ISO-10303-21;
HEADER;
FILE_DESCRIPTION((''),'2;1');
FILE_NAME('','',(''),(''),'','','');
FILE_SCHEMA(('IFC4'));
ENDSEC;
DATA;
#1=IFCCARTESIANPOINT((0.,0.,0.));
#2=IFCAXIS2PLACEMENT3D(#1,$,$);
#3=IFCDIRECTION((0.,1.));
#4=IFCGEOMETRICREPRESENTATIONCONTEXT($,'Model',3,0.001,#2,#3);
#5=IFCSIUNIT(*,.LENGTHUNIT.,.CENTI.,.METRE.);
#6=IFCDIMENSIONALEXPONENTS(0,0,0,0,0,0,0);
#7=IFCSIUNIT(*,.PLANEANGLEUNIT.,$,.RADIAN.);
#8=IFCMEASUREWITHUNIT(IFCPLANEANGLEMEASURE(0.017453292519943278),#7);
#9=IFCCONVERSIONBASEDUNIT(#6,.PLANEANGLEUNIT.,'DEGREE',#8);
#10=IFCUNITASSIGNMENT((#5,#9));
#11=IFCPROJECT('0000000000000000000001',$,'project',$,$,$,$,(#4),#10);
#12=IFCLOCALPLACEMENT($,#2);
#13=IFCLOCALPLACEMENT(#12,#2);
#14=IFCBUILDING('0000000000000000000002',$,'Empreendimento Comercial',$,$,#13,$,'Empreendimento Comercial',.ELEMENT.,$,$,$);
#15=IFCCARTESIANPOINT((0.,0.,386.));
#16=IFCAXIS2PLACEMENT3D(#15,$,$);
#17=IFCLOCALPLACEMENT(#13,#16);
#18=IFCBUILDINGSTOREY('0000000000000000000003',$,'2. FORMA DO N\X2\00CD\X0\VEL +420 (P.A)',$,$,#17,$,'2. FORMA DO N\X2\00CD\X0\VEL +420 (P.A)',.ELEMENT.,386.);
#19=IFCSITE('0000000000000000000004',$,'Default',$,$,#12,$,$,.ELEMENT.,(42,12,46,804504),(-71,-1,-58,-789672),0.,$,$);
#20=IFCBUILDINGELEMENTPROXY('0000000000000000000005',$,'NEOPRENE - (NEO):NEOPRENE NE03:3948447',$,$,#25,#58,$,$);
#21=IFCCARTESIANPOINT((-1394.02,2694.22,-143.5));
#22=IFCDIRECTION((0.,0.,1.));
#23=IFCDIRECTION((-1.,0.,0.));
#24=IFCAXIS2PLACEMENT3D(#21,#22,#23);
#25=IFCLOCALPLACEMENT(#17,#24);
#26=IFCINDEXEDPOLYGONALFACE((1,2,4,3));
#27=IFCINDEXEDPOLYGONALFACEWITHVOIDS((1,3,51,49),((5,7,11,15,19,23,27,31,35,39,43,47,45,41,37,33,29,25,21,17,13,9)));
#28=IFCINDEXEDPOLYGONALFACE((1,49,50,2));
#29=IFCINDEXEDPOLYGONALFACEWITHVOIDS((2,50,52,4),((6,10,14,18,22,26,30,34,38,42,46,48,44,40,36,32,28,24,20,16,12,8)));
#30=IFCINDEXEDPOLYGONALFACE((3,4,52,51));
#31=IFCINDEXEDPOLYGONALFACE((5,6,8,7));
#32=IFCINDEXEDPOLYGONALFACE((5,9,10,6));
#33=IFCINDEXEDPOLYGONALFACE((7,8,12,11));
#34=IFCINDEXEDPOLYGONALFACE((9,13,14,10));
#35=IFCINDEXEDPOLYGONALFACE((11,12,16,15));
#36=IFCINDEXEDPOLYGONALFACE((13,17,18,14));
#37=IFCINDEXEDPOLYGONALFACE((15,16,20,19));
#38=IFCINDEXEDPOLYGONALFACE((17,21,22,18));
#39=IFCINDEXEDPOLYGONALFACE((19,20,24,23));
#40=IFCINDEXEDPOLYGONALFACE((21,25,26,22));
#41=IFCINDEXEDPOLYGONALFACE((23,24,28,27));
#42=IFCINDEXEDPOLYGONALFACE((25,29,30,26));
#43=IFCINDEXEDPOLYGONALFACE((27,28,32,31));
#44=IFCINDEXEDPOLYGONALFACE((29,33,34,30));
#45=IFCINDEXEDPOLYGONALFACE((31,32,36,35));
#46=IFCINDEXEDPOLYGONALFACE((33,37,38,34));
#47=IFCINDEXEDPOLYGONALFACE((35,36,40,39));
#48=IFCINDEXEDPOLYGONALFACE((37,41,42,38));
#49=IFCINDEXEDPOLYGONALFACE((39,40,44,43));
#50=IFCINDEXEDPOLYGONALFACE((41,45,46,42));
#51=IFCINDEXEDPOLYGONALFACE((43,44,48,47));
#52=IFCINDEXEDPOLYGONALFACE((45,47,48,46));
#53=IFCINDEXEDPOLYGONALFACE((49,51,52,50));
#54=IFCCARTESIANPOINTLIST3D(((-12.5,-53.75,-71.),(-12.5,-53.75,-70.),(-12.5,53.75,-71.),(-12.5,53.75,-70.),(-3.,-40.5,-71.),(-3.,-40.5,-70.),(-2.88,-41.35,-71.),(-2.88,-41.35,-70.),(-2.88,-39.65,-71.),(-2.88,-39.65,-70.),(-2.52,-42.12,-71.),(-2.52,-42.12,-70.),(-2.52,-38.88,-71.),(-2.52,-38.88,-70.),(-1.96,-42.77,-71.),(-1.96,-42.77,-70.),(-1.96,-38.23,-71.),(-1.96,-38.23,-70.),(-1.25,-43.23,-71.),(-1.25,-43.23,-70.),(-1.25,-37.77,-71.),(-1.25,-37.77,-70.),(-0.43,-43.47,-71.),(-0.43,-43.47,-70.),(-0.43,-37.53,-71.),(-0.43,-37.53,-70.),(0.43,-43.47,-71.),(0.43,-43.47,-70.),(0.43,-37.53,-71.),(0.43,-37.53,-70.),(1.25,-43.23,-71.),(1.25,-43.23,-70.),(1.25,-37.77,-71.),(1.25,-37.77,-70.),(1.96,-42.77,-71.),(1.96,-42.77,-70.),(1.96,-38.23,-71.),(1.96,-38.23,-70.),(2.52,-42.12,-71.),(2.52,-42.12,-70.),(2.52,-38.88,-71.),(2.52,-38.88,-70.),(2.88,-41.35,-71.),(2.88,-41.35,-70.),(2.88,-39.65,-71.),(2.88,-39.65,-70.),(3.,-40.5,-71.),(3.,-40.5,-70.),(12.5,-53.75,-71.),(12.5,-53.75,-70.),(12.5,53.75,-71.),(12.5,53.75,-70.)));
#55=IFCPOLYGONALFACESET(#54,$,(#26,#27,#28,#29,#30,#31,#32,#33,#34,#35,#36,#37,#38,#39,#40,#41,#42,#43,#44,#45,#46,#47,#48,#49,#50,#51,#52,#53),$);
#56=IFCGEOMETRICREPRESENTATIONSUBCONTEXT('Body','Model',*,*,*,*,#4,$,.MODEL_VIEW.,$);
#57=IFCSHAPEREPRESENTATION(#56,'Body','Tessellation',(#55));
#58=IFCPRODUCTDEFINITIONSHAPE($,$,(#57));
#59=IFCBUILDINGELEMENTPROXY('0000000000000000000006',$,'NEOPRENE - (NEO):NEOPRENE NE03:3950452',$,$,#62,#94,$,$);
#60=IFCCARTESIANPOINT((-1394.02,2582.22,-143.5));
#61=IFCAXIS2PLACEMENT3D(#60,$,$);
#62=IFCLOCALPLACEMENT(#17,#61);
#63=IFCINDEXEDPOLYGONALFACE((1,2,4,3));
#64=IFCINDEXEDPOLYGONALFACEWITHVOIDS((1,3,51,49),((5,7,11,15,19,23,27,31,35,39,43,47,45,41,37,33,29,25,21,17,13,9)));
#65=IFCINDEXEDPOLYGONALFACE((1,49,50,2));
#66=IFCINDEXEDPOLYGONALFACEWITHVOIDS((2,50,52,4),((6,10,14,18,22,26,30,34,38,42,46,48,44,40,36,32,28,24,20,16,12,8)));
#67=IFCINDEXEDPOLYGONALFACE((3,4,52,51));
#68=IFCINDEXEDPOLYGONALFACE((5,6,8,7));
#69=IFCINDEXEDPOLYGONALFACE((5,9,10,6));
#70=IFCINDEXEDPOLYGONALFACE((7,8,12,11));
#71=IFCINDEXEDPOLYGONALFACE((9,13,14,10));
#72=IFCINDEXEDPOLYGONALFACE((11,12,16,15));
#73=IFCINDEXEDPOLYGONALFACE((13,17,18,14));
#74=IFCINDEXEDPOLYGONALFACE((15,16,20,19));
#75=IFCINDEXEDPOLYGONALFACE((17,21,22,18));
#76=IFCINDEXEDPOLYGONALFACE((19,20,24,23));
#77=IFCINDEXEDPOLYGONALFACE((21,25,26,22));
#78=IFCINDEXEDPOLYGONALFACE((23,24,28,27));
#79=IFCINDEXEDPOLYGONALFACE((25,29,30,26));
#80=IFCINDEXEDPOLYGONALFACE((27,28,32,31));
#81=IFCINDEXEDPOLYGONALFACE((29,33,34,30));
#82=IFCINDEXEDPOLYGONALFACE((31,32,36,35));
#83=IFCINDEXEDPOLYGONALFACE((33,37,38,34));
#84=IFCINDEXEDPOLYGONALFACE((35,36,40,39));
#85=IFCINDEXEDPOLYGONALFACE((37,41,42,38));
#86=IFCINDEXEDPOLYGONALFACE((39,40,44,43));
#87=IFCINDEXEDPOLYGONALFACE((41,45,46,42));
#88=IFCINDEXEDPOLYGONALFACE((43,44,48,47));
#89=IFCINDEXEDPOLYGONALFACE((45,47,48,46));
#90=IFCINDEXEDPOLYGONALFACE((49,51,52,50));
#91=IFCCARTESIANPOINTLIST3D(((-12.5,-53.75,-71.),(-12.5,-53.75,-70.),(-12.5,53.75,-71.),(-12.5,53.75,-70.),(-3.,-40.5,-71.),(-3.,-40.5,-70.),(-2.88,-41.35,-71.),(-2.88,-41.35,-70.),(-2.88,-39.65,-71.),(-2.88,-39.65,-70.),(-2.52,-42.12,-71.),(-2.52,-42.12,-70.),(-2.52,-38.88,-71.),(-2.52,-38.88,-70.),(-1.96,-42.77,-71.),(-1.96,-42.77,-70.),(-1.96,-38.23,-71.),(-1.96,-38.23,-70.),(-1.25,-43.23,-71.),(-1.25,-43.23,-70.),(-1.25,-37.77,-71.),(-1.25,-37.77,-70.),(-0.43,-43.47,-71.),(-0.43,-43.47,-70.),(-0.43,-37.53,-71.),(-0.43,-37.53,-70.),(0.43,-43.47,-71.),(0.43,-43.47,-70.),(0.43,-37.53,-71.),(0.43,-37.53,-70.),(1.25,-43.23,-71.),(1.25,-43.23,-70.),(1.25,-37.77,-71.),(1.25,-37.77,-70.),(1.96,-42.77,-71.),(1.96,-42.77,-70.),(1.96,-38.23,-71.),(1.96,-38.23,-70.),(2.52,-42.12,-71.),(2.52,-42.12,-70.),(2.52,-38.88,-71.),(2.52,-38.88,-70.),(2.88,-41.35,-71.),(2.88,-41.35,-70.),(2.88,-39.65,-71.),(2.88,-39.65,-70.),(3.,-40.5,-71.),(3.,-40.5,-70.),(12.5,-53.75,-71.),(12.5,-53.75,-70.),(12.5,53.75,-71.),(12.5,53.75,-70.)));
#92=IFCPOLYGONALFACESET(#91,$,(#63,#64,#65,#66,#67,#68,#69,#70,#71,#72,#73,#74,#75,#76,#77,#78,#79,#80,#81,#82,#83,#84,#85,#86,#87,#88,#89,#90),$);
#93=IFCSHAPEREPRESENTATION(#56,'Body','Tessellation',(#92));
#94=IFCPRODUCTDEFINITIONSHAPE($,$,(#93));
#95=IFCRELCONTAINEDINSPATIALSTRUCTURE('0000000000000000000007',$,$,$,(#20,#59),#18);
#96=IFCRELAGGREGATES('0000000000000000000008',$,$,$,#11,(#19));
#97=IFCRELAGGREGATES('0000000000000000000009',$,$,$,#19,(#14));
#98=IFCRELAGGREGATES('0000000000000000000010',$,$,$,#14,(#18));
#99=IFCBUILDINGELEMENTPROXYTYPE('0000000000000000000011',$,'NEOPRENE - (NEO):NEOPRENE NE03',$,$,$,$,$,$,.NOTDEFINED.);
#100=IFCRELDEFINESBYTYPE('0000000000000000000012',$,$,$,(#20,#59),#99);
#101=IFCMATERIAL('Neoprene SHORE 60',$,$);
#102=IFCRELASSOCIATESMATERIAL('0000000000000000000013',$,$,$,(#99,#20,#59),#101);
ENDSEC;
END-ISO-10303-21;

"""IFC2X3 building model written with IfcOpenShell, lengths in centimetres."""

from ifc_helpers import new_model, entity, si_unit, converted_unit, direction, frame, frame_2d, origin, place, context, subcontext, project, spatial, polyline, circle_curve, parameter, trimmed, segment, composite_curve, outline, extrude, source, transform, mapped, material, type_object, type_shapes, element, save


model = new_model("IFC2X3")

# Units and contexts
model_context = context("Model", 3, precision=0.001, world=origin(), true_north=direction((0.0, 1.0)))
body_context = subcontext(model_context, "Body", "Model", "MODEL_VIEW")
ifc_project = project(units=[si_unit("LENGTHUNIT", "METRE", prefix="CENTI"), converted_unit("PLANEANGLEUNIT", "DEGREE", entity("IfcPlaneAngleMeasure", 0.017453292519943278), si_unit("PLANEANGLEUNIT", "RADIAN"), dimensions=[0, 0, 0, 0, 0, 0, 0])], contexts=[model_context])

# Site, building, storey
site_placement = place(None, origin())
site = spatial("IfcSite", under=ifc_project, at=site_placement, Name="Default", CompositionType="ELEMENT", RefLatitude=(42, 12, 46, 804504), RefLongitude=(-71, -1, -58, -789672), RefElevation=0.0)
building_placement = place(site_placement, origin())
building = spatial("IfcBuilding", under=site, at=building_placement, Name="Empreendimento Comercial", LongName="Empreendimento Comercial", CompositionType="ELEMENT")
storey_placement = place(building_placement, frame((0.0, 0.0, 386.0)))
storey = spatial("IfcBuildingStorey", under=building, at=storey_placement, Name="2. FORMA DO NÍVEL +420 (P.A)", LongName="2. FORMA DO NÍVEL +420 (P.A)", CompositionType="ELEMENT", Elevation=386.0)

# Building element proxies
ifc_material = material(Name="Neoprene SHORE 60")
building_element_proxy_type_1 = type_object("IfcBuildingElementProxyType", Name="NEOPRENE - (NEO):NEOPRENE NE03", PredefinedType="NOTDEFINED", material=ifc_material)
shared_shape_1 = source(origin(), body_context, "Body", "SweptSolid", [
    extrude(outline(polyline([(-12.5, -53.75), (12.5, -53.75), (12.5, 53.75), (-12.5, 53.75), (-12.5, -53.75)]), holes=[composite_curve([segment(trimmed(circle_curve(frame_2d((0.0, 40.5), x_axis=(-1.0, 0.0)), 3.0), [parameter(0.0)], [parameter(180.0)], True, "PARAMETER"), False, "CONTINUOUS"), segment(trimmed(circle_curve(frame_2d((0.0, 40.5), x_axis=(-1.0, 0.0)), 3.0), [parameter(180.0)], [parameter(0.0)], True, "PARAMETER"), False, "CONTINUOUS")], self_intersect=False)]), frame((0.0, 0.0, -71.0), z_axis=(0.0, 0.0, 1.0), x_axis=(-1.0, 0.0, 0.0)), (0.0, 0.0, 1.0), 1.0),
])
type_shapes(building_element_proxy_type_1, [shared_shape_1])
proxy_1_placement = place(storey_placement, frame((-1394.02, 2694.22, -143.5), z_axis=(0.0, 0.0, 1.0), x_axis=(-1.0, 0.0, 0.0)))
element("IfcBuildingElementProxy", 1, at=proxy_1_placement, inside=storey, type_object=building_element_proxy_type_1, material=ifc_material, Name="NEOPRENE - (NEO):NEOPRENE NE03:3948447", context=body_context, shape_type="MappedRepresentation", body=[
    mapped(shared_shape_1, transform((0.0, 0.0, 0.0), scale=1.0)),
])
proxy_2_placement = place(storey_placement, frame((-1394.02, 2582.22, -143.5)))
element("IfcBuildingElementProxy", 2, at=proxy_2_placement, inside=storey, type_object=building_element_proxy_type_1, material=ifc_material, Name="NEOPRENE - (NEO):NEOPRENE NE03:3950452", context=body_context, shape_type="MappedRepresentation", body=[
    mapped(shared_shape_1, transform((0.0, 0.0, 0.0), scale=1.0)),
])

save(model, "model.ifc")
